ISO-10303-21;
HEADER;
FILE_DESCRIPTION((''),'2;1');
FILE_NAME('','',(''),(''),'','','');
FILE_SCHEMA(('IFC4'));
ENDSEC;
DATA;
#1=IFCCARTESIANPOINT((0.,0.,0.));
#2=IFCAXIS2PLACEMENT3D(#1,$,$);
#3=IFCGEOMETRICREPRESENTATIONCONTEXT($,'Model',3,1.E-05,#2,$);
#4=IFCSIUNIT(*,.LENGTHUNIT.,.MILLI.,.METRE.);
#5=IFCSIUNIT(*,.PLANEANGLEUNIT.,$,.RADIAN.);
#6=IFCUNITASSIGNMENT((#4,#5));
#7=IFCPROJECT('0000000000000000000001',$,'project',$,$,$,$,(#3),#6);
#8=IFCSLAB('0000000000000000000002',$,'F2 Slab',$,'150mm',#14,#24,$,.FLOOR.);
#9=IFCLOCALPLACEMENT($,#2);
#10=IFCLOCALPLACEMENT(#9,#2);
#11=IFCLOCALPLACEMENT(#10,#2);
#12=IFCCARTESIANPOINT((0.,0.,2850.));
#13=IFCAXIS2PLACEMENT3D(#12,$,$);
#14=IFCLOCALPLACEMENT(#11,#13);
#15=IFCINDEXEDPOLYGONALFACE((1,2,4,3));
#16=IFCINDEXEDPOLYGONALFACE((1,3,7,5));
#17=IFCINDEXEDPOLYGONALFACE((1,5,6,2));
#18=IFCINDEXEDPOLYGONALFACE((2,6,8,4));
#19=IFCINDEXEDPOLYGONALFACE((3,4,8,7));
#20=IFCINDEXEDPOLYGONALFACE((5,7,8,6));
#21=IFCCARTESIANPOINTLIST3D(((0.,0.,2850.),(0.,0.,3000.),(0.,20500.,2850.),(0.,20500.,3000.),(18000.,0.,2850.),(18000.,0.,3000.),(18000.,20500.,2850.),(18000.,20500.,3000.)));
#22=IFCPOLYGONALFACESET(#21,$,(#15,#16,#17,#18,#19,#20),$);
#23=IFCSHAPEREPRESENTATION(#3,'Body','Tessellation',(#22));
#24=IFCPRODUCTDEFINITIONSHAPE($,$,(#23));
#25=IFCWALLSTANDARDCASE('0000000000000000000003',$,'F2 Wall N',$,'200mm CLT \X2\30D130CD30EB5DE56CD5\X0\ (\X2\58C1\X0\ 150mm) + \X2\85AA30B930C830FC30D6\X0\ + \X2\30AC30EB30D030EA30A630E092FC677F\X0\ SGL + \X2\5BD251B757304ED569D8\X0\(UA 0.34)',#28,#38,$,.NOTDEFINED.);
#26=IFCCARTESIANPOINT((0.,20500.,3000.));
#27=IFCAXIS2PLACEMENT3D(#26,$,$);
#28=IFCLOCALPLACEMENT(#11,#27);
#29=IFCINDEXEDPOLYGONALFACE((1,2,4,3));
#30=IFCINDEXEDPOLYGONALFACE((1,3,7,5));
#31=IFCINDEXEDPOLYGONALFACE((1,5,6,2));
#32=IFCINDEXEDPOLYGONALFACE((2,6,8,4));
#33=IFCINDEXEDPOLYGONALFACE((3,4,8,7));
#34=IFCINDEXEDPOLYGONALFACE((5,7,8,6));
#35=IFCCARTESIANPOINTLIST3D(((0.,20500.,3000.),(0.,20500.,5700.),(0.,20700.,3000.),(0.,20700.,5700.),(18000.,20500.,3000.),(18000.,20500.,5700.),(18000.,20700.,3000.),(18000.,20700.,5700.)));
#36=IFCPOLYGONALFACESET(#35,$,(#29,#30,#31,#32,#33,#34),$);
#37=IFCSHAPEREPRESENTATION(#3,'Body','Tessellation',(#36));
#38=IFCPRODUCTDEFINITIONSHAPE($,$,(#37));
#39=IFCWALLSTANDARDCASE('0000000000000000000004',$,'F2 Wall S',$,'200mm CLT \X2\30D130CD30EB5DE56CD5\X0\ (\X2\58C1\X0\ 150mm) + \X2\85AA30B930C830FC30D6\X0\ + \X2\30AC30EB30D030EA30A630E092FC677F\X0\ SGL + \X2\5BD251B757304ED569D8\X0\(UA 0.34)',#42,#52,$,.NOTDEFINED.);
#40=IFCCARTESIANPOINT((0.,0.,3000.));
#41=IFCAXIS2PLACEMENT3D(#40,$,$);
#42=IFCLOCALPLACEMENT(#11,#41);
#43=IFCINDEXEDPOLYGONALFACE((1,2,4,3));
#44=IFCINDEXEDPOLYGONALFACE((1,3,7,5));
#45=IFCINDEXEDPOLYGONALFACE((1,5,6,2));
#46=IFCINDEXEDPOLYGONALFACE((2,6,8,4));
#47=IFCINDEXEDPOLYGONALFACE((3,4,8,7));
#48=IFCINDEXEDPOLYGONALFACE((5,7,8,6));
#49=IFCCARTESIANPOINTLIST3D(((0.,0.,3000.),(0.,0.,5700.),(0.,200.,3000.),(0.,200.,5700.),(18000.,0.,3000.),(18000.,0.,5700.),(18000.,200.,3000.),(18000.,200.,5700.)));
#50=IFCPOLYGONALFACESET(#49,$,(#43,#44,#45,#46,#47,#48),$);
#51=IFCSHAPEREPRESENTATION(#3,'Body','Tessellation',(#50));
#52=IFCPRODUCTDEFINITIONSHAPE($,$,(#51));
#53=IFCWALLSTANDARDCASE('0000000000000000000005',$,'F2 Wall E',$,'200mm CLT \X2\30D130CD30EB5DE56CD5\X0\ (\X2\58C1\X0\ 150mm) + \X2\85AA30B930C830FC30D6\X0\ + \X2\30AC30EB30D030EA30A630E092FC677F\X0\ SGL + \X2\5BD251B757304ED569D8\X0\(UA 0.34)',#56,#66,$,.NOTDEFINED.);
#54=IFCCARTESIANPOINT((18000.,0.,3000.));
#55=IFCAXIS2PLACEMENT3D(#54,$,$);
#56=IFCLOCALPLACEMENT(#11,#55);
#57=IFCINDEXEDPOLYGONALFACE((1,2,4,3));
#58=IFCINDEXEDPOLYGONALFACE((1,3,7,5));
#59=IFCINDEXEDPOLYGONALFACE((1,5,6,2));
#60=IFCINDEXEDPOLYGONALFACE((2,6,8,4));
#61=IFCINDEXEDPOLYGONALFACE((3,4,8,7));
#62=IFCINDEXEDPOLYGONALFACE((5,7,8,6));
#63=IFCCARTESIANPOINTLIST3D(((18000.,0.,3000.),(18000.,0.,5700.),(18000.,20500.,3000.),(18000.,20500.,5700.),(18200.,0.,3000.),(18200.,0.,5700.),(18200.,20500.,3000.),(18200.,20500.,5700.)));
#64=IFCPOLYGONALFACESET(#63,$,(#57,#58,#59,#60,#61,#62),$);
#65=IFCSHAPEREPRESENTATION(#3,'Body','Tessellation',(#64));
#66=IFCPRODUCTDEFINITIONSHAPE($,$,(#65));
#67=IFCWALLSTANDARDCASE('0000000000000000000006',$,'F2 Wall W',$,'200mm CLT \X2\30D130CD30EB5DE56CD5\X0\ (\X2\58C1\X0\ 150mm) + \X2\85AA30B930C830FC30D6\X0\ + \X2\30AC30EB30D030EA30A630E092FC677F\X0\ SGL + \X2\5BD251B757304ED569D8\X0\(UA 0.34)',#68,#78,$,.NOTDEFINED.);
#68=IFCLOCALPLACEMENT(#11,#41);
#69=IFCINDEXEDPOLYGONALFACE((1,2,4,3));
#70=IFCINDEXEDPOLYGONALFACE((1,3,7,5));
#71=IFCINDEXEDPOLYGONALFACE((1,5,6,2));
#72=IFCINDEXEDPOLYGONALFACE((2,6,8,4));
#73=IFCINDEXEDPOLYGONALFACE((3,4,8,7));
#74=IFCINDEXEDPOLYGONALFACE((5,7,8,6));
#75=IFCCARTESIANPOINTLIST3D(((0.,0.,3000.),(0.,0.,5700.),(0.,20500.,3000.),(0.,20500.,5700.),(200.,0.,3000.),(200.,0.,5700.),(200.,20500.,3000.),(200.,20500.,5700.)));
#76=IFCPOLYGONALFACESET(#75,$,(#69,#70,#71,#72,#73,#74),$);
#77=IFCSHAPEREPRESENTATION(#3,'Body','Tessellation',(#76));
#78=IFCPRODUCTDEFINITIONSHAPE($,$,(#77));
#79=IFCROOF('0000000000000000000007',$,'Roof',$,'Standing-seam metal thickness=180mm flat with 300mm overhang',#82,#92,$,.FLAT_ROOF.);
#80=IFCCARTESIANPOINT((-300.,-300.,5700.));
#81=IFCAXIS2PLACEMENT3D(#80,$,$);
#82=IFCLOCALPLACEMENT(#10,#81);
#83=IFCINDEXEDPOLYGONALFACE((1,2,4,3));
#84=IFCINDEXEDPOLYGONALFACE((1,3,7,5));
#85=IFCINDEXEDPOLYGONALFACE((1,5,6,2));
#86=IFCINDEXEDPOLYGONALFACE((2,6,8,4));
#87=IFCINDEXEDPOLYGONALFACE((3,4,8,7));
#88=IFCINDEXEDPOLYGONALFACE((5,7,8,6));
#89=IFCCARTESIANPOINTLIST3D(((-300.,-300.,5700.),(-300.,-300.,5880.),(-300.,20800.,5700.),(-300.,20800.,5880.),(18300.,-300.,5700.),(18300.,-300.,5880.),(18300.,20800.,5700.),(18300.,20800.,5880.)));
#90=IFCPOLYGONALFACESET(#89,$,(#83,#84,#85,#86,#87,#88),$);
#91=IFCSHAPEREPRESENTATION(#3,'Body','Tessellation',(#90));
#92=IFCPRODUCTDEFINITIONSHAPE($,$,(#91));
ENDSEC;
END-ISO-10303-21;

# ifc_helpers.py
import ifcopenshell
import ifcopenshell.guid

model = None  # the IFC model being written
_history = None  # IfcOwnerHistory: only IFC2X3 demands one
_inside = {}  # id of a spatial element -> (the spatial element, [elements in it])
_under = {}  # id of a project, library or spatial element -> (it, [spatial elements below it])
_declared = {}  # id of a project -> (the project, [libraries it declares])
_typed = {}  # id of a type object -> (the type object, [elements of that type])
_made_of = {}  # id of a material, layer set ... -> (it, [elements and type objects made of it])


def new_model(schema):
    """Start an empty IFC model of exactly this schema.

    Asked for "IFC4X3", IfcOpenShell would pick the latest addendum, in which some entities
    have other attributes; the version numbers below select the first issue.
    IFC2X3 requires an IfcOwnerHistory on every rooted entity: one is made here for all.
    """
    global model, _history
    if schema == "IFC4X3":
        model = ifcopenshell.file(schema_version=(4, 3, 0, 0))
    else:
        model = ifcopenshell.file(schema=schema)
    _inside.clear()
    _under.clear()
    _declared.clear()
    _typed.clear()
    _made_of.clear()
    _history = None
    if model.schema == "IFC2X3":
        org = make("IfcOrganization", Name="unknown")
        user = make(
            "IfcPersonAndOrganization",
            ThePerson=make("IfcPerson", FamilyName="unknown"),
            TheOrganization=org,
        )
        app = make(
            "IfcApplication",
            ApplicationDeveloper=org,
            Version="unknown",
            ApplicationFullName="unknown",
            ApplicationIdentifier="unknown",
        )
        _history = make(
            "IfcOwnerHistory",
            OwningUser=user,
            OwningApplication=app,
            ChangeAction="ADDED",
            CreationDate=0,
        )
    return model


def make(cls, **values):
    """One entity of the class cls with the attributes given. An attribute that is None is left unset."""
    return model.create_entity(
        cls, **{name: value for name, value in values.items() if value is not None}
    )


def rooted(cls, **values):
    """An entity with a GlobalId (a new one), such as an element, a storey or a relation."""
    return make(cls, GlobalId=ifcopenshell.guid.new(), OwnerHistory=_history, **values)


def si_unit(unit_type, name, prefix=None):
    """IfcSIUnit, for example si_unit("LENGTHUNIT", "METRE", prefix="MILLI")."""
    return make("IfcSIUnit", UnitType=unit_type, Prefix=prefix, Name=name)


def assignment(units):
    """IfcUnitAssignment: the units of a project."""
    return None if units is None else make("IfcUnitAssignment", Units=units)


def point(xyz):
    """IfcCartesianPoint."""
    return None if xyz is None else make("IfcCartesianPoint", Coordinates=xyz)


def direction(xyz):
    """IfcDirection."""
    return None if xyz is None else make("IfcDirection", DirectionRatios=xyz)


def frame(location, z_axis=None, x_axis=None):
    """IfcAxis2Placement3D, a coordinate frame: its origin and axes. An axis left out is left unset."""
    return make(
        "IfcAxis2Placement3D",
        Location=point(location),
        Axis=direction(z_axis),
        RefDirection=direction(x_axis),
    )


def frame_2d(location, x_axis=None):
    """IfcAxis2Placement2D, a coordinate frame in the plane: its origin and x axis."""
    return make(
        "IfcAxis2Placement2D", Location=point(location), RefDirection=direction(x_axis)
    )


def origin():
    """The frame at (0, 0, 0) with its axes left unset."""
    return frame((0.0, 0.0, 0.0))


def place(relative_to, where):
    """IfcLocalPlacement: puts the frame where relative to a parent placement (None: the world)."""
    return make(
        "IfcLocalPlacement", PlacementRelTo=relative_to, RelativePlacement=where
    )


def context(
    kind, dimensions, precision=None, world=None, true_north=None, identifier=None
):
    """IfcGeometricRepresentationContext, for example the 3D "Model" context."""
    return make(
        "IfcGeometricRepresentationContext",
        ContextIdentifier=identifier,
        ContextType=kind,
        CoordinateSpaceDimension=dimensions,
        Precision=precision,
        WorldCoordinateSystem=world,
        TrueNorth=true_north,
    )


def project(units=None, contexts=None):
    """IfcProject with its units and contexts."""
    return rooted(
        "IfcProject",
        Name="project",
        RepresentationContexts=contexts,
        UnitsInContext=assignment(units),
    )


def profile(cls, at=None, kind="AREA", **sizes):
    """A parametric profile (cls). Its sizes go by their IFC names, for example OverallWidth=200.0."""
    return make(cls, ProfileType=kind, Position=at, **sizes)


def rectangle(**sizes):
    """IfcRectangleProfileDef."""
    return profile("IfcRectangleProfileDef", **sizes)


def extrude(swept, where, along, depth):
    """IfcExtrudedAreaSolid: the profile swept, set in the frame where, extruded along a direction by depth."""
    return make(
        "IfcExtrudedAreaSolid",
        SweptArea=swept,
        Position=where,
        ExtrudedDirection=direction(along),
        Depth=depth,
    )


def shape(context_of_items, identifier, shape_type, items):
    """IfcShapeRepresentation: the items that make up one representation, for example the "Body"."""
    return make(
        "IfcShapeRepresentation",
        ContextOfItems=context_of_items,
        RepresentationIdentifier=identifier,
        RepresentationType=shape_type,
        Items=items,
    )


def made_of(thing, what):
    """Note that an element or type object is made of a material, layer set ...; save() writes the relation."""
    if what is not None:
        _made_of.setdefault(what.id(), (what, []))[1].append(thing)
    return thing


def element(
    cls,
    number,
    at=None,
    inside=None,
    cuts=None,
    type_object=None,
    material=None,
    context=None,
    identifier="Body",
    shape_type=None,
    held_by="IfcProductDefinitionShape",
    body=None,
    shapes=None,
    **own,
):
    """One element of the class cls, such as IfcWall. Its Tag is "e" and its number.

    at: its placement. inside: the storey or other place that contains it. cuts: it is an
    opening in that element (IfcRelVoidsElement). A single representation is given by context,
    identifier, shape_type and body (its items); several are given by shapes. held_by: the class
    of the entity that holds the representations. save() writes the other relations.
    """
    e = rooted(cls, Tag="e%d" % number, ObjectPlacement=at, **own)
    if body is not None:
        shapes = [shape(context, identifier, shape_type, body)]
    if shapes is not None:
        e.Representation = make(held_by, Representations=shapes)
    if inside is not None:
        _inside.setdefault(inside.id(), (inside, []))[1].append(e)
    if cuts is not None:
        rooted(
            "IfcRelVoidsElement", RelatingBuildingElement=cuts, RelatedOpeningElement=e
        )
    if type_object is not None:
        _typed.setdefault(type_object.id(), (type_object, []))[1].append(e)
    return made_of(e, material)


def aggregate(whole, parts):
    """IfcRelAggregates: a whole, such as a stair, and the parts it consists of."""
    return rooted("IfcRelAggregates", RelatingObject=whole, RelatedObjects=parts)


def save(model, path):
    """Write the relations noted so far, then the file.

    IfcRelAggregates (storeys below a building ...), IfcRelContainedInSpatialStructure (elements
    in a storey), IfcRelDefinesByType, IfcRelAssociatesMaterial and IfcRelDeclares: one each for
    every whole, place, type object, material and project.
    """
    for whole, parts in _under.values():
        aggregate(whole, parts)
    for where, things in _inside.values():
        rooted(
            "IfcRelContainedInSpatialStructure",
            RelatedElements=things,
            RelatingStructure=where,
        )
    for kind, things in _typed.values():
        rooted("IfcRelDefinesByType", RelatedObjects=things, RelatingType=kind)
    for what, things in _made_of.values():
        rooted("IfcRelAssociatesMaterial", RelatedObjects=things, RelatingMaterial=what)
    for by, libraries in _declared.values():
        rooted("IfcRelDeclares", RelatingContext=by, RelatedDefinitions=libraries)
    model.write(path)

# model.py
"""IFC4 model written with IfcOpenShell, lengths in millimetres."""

from ifc_helpers import new_model, si_unit, frame, frame_2d, origin, place, context, project, rectangle, extrude, element, save


model = new_model("IFC4")

# Units and contexts
model_context = context("Model", 3, precision=1e-05, world=origin())
ifc_project = project(units=[si_unit("LENGTHUNIT", "METRE", prefix="MILLI"), si_unit("PLANEANGLEUNIT", "RADIAN")], contexts=[model_context])

# Slab
placement_1 = place(None, origin())
placement_2 = place(placement_1, origin())
placement_3 = place(placement_2, origin())
slab_placement = place(placement_3, frame((0.0, 0.0, 2850.0)))
element("IfcSlab", 1, at=slab_placement, Name="F2 Slab", ObjectType="150mm", PredefinedType="FLOOR", context=model_context, shape_type="SweptSolid", body=[
    extrude(rectangle(XDim=18000.0, YDim=20500.0, at=frame_2d((9000.0, 10250.0))), frame((0.0, 0.0, 2850.0)), (0.0, 0.0, 1.0), 150.0),
])

# Walls
wall_1_placement = place(placement_3, frame((0.0, 20500.0, 3000.0)))
element("IfcWallStandardCase", 2, at=wall_1_placement, Name="F2 Wall N", ObjectType="200mm CLT パネル工法 (壁 150mm) + 薪ストーブ + ガルバリウム鋼板 SGL + 寒冷地仕様(UA 0.34)", PredefinedType="NOTDEFINED", context=model_context, shape_type="SweptSolid", body=[
    extrude(rectangle(XDim=18000.0, YDim=200.0, at=frame_2d((9000.0, 100.0))), frame((0.0, 20500.0, 3000.0)), (0.0, 0.0, 1.0), 2700.0),
])
wall_2_placement = place(placement_3, frame((0.0, 0.0, 3000.0)))
element("IfcWallStandardCase", 3, at=wall_2_placement, Name="F2 Wall S", ObjectType="200mm CLT パネル工法 (壁 150mm) + 薪ストーブ + ガルバリウム鋼板 SGL + 寒冷地仕様(UA 0.34)", PredefinedType="NOTDEFINED", context=model_context, shape_type="SweptSolid", body=[
    extrude(rectangle(XDim=18000.0, YDim=200.0, at=frame_2d((9000.0, 100.0))), frame((0.0, 0.0, 3000.0)), (0.0, 0.0, 1.0), 2700.0),
])
wall_3_placement = place(placement_3, frame((18000.0, 0.0, 3000.0)))
element("IfcWallStandardCase", 4, at=wall_3_placement, Name="F2 Wall E", ObjectType="200mm CLT パネル工法 (壁 150mm) + 薪ストーブ + ガルバリウム鋼板 SGL + 寒冷地仕様(UA 0.34)", PredefinedType="NOTDEFINED", context=model_context, shape_type="SweptSolid", body=[
    extrude(rectangle(XDim=200.0, YDim=20500.0, at=frame_2d((100.0, 10250.0))), frame((18000.0, 0.0, 3000.0)), (0.0, 0.0, 1.0), 2700.0),
])
wall_4_placement = place(placement_3, frame((0.0, 0.0, 3000.0)))
element("IfcWallStandardCase", 5, at=wall_4_placement, Name="F2 Wall W", ObjectType="200mm CLT パネル工法 (壁 150mm) + 薪ストーブ + ガルバリウム鋼板 SGL + 寒冷地仕様(UA 0.34)", PredefinedType="NOTDEFINED", context=model_context, shape_type="SweptSolid", body=[
    extrude(rectangle(XDim=200.0, YDim=20500.0, at=frame_2d((100.0, 10250.0))), frame((0.0, 0.0, 3000.0)), (0.0, 0.0, 1.0), 2700.0),
])

# Roof
roof_placement = place(placement_2, frame((-300.0, -300.0, 5700.0)))
element("IfcRoof", 6, at=roof_placement, Name="Roof", ObjectType="Standing-seam metal thickness=180mm flat with 300mm overhang", PredefinedType="FLAT_ROOF", context=model_context, shape_type="SweptSolid", body=[
    extrude(rectangle(XDim=18600.0, YDim=21100.0, at=frame_2d((9300.0, 10550.0))), frame((-300.0, -300.0, 5700.0)), (0.0, 0.0, 1.0), 180.0),
])

save(model, "model.ifc")
